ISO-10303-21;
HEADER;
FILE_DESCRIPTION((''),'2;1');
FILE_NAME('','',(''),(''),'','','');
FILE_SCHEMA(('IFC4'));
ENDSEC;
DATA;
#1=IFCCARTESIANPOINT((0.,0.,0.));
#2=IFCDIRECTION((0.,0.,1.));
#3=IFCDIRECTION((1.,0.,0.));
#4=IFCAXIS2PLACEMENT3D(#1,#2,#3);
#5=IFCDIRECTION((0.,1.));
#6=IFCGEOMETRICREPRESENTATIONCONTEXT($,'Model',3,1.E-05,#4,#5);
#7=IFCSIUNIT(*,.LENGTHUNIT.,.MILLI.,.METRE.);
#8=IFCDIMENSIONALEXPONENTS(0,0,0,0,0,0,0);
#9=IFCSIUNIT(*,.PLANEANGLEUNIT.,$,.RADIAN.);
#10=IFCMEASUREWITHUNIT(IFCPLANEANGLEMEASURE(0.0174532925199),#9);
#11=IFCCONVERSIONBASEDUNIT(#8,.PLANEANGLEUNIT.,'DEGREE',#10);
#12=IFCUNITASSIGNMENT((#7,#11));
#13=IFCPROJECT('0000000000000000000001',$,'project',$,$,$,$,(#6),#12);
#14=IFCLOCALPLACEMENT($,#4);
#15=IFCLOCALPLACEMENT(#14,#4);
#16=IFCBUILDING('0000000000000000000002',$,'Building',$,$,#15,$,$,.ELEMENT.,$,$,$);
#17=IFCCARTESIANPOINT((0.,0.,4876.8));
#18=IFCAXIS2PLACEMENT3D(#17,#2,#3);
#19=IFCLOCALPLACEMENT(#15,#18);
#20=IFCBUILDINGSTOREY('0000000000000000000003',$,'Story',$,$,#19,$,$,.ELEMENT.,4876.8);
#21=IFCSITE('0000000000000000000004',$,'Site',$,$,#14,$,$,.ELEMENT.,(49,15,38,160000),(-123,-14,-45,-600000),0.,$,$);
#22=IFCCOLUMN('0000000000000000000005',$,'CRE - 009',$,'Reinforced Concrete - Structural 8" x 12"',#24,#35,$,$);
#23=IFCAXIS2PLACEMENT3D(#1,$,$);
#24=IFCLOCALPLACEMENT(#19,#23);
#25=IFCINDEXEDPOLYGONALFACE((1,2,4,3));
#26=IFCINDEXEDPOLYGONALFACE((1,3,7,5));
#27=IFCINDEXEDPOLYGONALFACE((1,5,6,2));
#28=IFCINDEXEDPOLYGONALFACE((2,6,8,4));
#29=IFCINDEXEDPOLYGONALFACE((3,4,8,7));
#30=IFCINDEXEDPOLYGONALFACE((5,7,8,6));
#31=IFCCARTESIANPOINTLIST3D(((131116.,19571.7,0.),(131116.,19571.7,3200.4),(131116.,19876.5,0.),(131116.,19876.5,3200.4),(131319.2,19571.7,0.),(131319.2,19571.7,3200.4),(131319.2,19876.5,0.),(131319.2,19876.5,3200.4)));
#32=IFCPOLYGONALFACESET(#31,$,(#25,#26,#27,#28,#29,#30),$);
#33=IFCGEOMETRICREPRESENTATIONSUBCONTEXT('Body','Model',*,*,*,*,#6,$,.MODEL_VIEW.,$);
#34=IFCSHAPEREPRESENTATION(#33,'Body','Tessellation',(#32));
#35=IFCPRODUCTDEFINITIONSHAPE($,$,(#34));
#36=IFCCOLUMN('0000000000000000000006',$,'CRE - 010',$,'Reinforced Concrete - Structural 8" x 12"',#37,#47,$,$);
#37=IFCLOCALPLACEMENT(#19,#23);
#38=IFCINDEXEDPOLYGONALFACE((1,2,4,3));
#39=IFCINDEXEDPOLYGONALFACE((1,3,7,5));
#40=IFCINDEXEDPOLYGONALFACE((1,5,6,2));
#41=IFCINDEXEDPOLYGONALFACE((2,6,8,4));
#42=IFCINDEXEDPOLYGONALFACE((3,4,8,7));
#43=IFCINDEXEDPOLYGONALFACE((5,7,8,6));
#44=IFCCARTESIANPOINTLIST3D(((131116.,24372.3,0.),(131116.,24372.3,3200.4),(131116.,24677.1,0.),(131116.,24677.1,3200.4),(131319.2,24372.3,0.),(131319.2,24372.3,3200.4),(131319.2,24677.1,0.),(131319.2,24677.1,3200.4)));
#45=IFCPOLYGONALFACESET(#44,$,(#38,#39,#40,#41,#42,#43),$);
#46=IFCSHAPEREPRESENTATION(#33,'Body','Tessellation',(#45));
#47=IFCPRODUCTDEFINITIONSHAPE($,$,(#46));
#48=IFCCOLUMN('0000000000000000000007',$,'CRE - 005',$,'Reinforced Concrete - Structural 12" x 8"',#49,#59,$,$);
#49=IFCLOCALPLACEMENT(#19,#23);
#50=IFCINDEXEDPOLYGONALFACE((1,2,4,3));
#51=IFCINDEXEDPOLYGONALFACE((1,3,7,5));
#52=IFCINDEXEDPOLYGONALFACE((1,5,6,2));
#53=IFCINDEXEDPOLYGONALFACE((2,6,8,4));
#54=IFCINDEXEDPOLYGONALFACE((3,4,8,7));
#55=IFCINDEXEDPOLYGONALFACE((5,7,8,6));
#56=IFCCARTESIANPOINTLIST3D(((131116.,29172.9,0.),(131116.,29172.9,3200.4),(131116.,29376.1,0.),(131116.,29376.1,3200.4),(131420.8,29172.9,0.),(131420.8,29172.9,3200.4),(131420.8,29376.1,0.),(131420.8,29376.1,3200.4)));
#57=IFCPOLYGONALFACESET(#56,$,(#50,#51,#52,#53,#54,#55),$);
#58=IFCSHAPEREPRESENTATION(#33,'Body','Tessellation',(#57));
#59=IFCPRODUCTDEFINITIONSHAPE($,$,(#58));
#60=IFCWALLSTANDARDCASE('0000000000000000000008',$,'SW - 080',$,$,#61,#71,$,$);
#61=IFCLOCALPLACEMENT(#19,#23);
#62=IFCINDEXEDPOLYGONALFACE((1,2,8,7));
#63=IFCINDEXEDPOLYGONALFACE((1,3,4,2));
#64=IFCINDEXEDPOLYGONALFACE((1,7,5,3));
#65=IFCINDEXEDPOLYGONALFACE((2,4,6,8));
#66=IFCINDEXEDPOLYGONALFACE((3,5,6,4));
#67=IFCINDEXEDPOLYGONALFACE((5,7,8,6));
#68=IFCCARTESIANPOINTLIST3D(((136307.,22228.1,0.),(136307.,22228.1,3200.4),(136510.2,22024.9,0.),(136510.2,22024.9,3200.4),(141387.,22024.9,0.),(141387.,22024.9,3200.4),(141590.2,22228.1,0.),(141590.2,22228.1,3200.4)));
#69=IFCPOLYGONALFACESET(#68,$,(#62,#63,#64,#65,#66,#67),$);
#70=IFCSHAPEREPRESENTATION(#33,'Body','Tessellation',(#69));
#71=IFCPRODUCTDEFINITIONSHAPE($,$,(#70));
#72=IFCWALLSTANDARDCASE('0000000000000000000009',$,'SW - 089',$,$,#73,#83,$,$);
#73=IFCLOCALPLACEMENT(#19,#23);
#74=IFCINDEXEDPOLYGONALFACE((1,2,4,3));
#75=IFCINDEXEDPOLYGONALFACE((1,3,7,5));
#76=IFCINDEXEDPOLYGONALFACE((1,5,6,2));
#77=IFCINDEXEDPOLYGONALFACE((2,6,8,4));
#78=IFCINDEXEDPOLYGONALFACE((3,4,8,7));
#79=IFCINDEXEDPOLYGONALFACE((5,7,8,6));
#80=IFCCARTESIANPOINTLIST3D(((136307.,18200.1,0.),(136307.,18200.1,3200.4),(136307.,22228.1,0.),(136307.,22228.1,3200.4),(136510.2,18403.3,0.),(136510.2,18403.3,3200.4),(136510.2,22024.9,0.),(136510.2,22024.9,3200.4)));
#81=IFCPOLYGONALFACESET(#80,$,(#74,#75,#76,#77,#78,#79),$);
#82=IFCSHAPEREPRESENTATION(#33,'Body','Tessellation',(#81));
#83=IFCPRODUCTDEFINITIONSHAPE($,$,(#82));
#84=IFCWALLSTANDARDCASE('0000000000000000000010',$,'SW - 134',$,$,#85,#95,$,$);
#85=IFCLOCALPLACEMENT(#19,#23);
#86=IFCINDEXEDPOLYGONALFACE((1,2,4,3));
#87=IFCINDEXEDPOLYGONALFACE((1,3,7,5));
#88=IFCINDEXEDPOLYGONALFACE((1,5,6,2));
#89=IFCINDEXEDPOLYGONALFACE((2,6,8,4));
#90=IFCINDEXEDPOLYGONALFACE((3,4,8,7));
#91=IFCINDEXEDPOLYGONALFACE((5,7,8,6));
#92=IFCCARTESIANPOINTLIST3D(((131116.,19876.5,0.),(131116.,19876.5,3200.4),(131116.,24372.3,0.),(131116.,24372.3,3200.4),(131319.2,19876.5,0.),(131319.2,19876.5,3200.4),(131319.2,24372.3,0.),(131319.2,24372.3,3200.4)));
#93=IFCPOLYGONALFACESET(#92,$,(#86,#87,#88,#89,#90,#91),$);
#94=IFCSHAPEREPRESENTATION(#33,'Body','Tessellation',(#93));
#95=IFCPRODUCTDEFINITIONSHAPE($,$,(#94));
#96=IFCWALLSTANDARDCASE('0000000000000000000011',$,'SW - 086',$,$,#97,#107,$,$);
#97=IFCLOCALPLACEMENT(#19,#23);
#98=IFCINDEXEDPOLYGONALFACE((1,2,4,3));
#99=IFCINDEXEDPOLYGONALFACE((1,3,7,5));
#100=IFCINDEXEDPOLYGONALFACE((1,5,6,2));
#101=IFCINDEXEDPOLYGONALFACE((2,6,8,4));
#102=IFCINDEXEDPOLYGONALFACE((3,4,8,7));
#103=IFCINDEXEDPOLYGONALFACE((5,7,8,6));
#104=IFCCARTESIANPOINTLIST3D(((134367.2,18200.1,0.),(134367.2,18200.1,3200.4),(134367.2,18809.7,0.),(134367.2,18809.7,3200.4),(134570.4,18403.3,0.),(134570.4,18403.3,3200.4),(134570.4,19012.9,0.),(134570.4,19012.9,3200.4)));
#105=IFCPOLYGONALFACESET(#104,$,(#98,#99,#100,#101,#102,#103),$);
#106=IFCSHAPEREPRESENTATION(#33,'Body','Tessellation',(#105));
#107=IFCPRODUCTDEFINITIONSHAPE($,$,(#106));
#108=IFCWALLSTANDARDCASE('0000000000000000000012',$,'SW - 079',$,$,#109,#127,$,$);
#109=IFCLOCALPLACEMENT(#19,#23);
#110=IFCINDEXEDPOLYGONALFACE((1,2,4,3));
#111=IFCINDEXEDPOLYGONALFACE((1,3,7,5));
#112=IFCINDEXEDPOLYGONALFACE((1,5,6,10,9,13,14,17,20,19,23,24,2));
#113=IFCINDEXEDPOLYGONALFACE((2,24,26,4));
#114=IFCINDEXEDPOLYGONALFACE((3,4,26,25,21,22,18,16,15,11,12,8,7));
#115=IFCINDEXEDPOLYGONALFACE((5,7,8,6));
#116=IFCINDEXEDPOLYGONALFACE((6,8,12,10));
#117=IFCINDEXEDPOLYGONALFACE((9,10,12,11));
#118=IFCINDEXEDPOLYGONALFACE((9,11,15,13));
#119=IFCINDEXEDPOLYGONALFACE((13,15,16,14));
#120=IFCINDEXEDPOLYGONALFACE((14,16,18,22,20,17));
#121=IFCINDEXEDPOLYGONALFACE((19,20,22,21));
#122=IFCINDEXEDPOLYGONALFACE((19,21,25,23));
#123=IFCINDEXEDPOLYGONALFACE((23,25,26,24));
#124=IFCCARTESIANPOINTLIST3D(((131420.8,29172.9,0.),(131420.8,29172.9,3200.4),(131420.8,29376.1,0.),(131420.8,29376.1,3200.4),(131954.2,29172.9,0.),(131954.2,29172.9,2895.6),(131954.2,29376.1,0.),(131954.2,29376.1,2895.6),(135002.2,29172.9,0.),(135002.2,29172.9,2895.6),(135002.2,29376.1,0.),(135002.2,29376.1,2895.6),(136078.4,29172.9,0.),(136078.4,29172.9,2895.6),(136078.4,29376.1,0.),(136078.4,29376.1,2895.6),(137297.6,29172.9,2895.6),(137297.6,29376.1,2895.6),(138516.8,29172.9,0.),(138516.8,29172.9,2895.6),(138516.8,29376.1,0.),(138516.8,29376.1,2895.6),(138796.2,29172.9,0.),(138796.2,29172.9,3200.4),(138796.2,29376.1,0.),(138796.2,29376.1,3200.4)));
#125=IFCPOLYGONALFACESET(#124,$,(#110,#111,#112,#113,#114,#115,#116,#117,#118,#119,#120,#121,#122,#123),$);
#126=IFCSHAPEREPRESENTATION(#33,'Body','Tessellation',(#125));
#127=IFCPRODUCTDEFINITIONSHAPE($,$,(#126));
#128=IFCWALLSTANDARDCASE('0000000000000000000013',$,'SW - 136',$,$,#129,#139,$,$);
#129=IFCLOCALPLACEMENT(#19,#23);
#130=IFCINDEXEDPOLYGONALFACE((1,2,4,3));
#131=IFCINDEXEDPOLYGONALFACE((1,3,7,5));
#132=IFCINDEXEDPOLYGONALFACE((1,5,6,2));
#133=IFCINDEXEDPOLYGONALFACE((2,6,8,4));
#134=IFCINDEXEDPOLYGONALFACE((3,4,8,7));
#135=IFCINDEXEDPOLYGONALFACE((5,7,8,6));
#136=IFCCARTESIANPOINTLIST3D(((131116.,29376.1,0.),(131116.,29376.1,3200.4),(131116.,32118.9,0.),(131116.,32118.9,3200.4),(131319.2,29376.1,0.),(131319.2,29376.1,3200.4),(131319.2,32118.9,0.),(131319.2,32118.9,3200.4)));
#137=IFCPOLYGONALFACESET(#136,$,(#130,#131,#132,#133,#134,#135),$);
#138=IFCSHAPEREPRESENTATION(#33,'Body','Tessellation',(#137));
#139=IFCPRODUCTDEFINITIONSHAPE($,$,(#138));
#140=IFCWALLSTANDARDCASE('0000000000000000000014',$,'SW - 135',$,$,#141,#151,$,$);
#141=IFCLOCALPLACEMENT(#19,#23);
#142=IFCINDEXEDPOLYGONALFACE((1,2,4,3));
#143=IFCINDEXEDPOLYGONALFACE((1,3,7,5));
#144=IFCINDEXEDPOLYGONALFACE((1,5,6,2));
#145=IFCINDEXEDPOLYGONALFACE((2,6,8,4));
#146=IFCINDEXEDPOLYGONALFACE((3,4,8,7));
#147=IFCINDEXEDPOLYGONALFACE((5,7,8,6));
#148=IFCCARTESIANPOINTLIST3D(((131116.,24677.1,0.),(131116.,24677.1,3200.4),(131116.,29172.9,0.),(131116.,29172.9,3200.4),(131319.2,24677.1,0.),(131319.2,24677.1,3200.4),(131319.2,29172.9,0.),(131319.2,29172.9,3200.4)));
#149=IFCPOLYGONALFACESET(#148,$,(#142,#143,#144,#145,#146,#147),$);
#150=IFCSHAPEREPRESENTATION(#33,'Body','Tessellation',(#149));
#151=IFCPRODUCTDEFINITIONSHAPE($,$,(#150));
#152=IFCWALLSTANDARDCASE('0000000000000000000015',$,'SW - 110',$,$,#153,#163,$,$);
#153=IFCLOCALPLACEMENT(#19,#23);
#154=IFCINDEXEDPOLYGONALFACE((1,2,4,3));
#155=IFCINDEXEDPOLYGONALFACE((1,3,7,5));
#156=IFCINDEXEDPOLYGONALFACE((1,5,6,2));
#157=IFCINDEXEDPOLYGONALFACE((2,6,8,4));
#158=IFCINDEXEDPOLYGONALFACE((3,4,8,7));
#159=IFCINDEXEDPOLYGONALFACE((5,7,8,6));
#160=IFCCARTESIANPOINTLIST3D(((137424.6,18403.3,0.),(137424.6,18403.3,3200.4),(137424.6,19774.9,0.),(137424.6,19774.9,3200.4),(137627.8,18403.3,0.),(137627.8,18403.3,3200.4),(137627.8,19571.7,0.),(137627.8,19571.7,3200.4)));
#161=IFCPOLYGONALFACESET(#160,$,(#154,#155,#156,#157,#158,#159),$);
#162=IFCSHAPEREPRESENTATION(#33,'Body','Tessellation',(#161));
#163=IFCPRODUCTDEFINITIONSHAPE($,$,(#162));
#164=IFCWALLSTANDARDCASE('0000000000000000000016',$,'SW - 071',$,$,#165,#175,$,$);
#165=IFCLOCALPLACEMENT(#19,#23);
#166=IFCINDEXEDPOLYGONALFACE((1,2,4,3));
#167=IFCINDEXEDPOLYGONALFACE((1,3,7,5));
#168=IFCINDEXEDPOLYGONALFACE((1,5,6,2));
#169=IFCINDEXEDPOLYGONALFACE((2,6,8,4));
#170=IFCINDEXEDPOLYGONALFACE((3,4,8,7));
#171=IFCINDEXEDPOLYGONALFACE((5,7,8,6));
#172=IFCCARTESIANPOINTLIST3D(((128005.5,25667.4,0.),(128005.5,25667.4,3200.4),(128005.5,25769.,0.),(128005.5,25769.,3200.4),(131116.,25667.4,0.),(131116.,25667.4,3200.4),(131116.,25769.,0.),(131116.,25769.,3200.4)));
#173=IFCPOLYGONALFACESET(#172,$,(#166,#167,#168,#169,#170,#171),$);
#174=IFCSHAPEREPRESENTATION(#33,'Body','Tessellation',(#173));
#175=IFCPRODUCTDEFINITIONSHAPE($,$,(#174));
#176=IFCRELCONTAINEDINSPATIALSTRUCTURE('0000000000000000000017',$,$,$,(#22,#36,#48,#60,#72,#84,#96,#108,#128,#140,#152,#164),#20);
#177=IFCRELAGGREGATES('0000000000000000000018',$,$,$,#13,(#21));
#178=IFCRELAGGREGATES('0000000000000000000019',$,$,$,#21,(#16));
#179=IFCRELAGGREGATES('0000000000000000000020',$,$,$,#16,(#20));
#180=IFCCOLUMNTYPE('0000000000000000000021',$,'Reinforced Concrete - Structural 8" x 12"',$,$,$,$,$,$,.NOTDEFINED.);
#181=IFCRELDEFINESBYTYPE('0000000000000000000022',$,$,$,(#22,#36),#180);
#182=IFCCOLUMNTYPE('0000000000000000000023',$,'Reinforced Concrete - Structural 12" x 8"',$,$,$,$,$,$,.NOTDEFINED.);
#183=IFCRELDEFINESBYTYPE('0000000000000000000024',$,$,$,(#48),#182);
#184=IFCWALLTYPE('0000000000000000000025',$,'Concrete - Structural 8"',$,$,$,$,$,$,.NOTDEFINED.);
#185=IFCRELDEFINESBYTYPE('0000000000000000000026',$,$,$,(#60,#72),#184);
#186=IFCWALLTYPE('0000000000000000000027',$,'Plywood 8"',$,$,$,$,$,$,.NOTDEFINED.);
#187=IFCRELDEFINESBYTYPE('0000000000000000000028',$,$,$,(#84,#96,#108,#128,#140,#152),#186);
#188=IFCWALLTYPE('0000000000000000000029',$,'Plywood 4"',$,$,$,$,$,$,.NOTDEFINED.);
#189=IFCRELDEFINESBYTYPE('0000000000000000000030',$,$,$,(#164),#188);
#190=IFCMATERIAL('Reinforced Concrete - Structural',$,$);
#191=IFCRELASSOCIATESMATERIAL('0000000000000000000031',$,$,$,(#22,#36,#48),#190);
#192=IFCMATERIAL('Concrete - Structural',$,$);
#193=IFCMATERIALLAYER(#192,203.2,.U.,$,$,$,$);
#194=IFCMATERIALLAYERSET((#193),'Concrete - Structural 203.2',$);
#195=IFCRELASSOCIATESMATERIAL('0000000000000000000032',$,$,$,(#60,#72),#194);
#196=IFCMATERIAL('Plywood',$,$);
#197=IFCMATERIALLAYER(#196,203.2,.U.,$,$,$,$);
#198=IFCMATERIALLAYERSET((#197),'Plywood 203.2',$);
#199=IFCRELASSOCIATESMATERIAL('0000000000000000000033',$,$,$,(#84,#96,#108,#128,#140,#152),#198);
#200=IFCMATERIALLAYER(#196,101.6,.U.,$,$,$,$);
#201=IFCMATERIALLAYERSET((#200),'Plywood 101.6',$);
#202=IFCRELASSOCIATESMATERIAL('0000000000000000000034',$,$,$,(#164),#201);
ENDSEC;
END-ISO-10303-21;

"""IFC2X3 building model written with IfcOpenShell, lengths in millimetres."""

from ifc_helpers import new_model, entity, si_unit, converted_unit, direction, frame, origin_with_axes, origin_2d_with_axis, place, context, subcontext, project, spatial, polyline, rectangle, outline, extrude, material, layer, layer_set, layer_usage, type_object, element, save


model = new_model("IFC2X3")

# Units and contexts
model_context = context("Model", 3, precision=1e-05, world=origin_with_axes(), true_north=direction((0.0, 1.0)))
body_context = subcontext(model_context, "Body", "Model", "MODEL_VIEW")
ifc_project = project(units=[si_unit("LENGTHUNIT", "METRE", prefix="MILLI"), converted_unit("PLANEANGLEUNIT", "DEGREE", entity("IfcPlaneAngleMeasure", 0.0174532925199), si_unit("PLANEANGLEUNIT", "RADIAN"), dimensions=[0, 0, 0, 0, 0, 0, 0])], contexts=[model_context])

# Site, building, storey
site_placement = place(None, origin_with_axes())
site = spatial("IfcSite", under=ifc_project, at=site_placement, Name="Site", CompositionType="ELEMENT", RefLatitude=(49, 15, 38, 160000), RefLongitude=(-123, -14, -45, -600000), RefElevation=0.0)
building_placement = place(site_placement, origin_with_axes())
building = spatial("IfcBuilding", under=site, at=building_placement, Name="Building", CompositionType="ELEMENT")
storey_placement = place(building_placement, frame((0.0, 0.0, 4876.8), z_axis=(0.0, 0.0, 1.0), x_axis=(1.0, 0.0, 0.0)))
storey = spatial("IfcBuildingStorey", under=building, at=storey_placement, Name="Story", CompositionType="ELEMENT", Elevation=4876.8)

# Columns
ifc_material_1 = material(Name="Reinforced Concrete - Structural")
column_type_1 = type_object("IfcColumnType", Name="Reinforced Concrete - Structural 8\" x 12\"", PredefinedType="NOTDEFINED")
for number, where, z_axis, x_axis, name in (
    (1, (131217.6, 19724.1, 0.0), (0.0, 0.0, 1.0), (1.0, 0.0, 0.0), "CRE - 009"),
    (2, (131217.6, 24524.7, 0.0), (0.0, 0.0, 1.0), (1.0, 0.0, 0.0), "CRE - 010"),
):
    element("IfcColumn", number, at=place(storey_placement, frame(where, z_axis=z_axis, x_axis=x_axis)), inside=storey, type_object=column_type_1, material=ifc_material_1, Name=name, ObjectType="Reinforced Concrete - Structural 8\" x 12\"", context=body_context, shape_type="SweptSolid", body=[
        extrude(rectangle(XDim=203.2, YDim=304.8, at=origin_2d_with_axis()), origin_with_axes(), (0.0, 0.0, 1.0), 3200.4),
    ])
column_type_2 = type_object("IfcColumnType", Name="Reinforced Concrete - Structural 12\" x 8\"", PredefinedType="NOTDEFINED")
column_placement = place(storey_placement, frame((131268.4, 29274.5, 0.0), z_axis=(0.0, 0.0, 1.0), x_axis=(1.0, 0.0, 0.0)))
element("IfcColumn", 3, at=column_placement, inside=storey, type_object=column_type_2, material=ifc_material_1, Name="CRE - 005", ObjectType="Reinforced Concrete - Structural 12\" x 8\"", context=body_context, shape_type="SweptSolid", body=[
    extrude(rectangle(XDim=304.8, YDim=203.2, at=origin_2d_with_axis()), origin_with_axes(), (0.0, 0.0, 1.0), 3200.4),
])

# Walls
ifc_material_2 = material(Name="Concrete - Structural")
ifc_layer_1 = layer(ifc_material_2, 203.2, ventilated="UNKNOWN")
ifc_layer_set_1 = layer_set([ifc_layer_1], Name="Concrete - Structural 203.2")
ifc_layer_usage_1 = layer_usage(ifc_layer_set_1, "AXIS2", "POSITIVE", 0.0)
wall_type_1 = type_object("IfcWallType", Name="Concrete - Structural 8\"", PredefinedType="NOTDEFINED")
wall_1_placement = place(storey_placement, frame((136510.2, 22024.9, 0.0), z_axis=(0.0, 0.0, 1.0), x_axis=(1.0, 0.0, 0.0)))
element("IfcWallStandardCase", 4, at=wall_1_placement, inside=storey, type_object=wall_type_1, material=ifc_layer_usage_1, Name="SW - 080", context=body_context, shape_type="SweptSolid", body=[
    extrude(outline(polyline([(0.0, 0.0), (4876.8, 0.0), (5080.0, 203.2), (-203.2, 203.2), (0.0, 0.0)])), origin_with_axes(), (0.0, 0.0, 1.0), 3200.4),
])
ifc_layer_usage_2 = layer_usage(ifc_layer_set_1, "AXIS2", "NEGATIVE", 0.0)
wall_2_placement = place(storey_placement, frame((136510.2, 22024.9, 0.0), z_axis=(0.0, 0.0, 1.0), x_axis=(0.0, -1.0, 0.0)))
element("IfcWallStandardCase", 5, at=wall_2_placement, inside=storey, type_object=wall_type_1, material=ifc_layer_usage_2, Name="SW - 089", context=body_context, shape_type="SweptSolid", body=[
    extrude(outline(polyline([(-203.2, -203.2), (3824.8, -203.2), (3621.6, 0.0), (0.0, 0.0), (-203.2, -203.2)])), origin_with_axes(), (0.0, 0.0, 1.0), 3200.4),
])

# Walls
ifc_material_3 = material(Name="Plywood")
ifc_layer_2 = layer(ifc_material_3, 203.2, ventilated="UNKNOWN")
ifc_layer_set_2 = layer_set([ifc_layer_2], Name="Plywood 203.2")
ifc_layer_usage_3 = layer_usage(ifc_layer_set_2, "AXIS2", "NEGATIVE", 0.0)
wall_type_2 = type_object("IfcWallType", Name="Plywood 8\"", PredefinedType="NOTDEFINED")
wall_3_placement = place(storey_placement, frame((131116.0, 19876.5, 0.0), z_axis=(0.0, 0.0, 1.0), x_axis=(0.0, 1.0, 0.0)))
element("IfcWallStandardCase", 6, at=wall_3_placement, inside=storey, type_object=wall_type_2, material=ifc_layer_usage_3, Name="SW - 134", context=body_context, shape_type="SweptSolid", body=[
    extrude(outline(polyline([(0.0, -203.2), (4495.8, -203.2), (4495.8, 0.0), (0.0, 0.0), (0.0, -203.2)])), origin_with_axes(), (0.0, 0.0, 1.0), 3200.4),
])
ifc_layer_usage_4 = layer_usage(ifc_layer_set_2, "AXIS2", "POSITIVE", 0.0)
wall_4_placement = place(storey_placement, frame((134367.2, 19012.9, 0.0), z_axis=(0.0, 0.0, 1.0), x_axis=(0.0, -1.0, 0.0)))
element("IfcWallStandardCase", 7, at=wall_4_placement, inside=storey, type_object=wall_type_2, material=ifc_layer_usage_4, Name="SW - 086", context=body_context, shape_type="SweptSolid", body=[
    extrude(outline(polyline([(203.2, 0.0), (812.8, 0.0), (609.6, 203.2), (0.0, 203.2), (203.2, 0.0)])), origin_with_axes(), (0.0, 0.0, 1.0), 3200.4),
])

# Wall, openings
ifc_layer_usage_5 = layer_usage(ifc_layer_set_2, "AXIS2", "POSITIVE", 0.0)
wall_5_placement = place(storey_placement, frame((131420.8, 29172.9, 0.0), z_axis=(0.0, 0.0, 1.0), x_axis=(1.0, 0.0, 0.0)))
wall_5 = element("IfcWallStandardCase", 8, at=wall_5_placement, inside=storey, type_object=wall_type_2, material=ifc_layer_usage_5, Name="SW - 079", context=body_context, shape_type="SweptSolid", body=[
    extrude(outline(polyline([(0.0, 0.0), (7375.4, 0.0), (7375.4, 203.2), (0.0, 203.2), (0.0, 0.0)])), origin_with_axes(), (0.0, 0.0, 1.0), 3200.4),
])
opening_1_placement = place(wall_5_placement, frame((5267.2, 0.0, 0.0), z_axis=(0.0, 0.0, 1.0), x_axis=(1.0, 0.0, 0.0)))
element("IfcOpeningElement", 9, at=opening_1_placement, cuts=wall_5, context=body_context, shape_type="SweptSolid", body=[
    extrude(rectangle(XDim=1219.2, YDim=2895.6, at=origin_2d_with_axis()), frame((0.0, -203.2, 1447.8), z_axis=(0.0, 1.0, 0.0), x_axis=(1.0, 0.0, 0.0)), (0.0, 0.0, 1.0), 609.6),
])
opening_2_placement = place(wall_5_placement, frame((6486.4, 0.0, 0.0), z_axis=(0.0, 0.0, 1.0), x_axis=(1.0, 0.0, 0.0)))
element("IfcOpeningElement", 10, at=opening_2_placement, cuts=wall_5, context=body_context, shape_type="SweptSolid", body=[
    extrude(rectangle(XDim=1219.2, YDim=2895.6, at=origin_2d_with_axis()), frame((0.0, -203.2, 1447.8), z_axis=(0.0, -1.0, 0.0), x_axis=(-1.0, 0.0, 0.0)), (0.0, 0.0, -1.0), 609.6),
])
opening_3_placement = place(wall_5_placement, frame((2057.4, 0.0, 0.0), z_axis=(0.0, 0.0, 1.0), x_axis=(1.0, 0.0, 0.0)))
element("IfcOpeningElement", 11, at=opening_3_placement, cuts=wall_5, context=body_context, shape_type="SweptSolid", body=[
    extrude(rectangle(XDim=3048.0, YDim=2895.6, at=origin_2d_with_axis()), frame((0.0, -203.2, 1447.8), z_axis=(0.0, -1.0, 0.0), x_axis=(-1.0, 0.0, 0.0)), (0.0, 0.0, -1.0), 609.6),
])

# Walls
ifc_layer_usage_6 = layer_usage(ifc_layer_set_2, "AXIS2", "NEGATIVE", 0.0)
wall_6_placement = place(storey_placement, frame((131116.0, 29376.1, 0.0), z_axis=(0.0, 0.0, 1.0), x_axis=(0.0, 1.0, 0.0)))
element("IfcWallStandardCase", 12, at=wall_6_placement, inside=storey, type_object=wall_type_2, material=ifc_layer_usage_6, Name="SW - 136", context=body_context, shape_type="SweptSolid", body=[
    extrude(outline(polyline([(0.0, -203.2), (2742.9, -203.2), (2742.9, 0.0), (0.0, 0.0), (0.0, -203.2)])), origin_with_axes(), (0.0, 0.0, 1.0), 3200.4),
])
ifc_layer_usage_7 = layer_usage(ifc_layer_set_2, "AXIS2", "NEGATIVE", 0.0)
wall_7_placement = place(storey_placement, frame((131116.0, 24677.1, 0.0), z_axis=(0.0, 0.0, 1.0), x_axis=(0.0, 1.0, 0.0)))
element("IfcWallStandardCase", 13, at=wall_7_placement, inside=storey, type_object=wall_type_2, material=ifc_layer_usage_7, Name="SW - 135", context=body_context, shape_type="SweptSolid", body=[
    extrude(outline(polyline([(0.0, -203.2), (4495.8, -203.2), (4495.8, 0.0), (0.0, 0.0), (0.0, -203.2)])), origin_with_axes(), (0.0, 0.0, 1.0), 3200.4),
])
ifc_layer_usage_8 = layer_usage(ifc_layer_set_2, "AXIS2", "POSITIVE", 0.0)
wall_8_placement = place(storey_placement, frame((137424.6, 19774.9, 0.0), z_axis=(0.0, 0.0, 1.0), x_axis=(0.0, -1.0, 0.0)))
element("IfcWallStandardCase", 14, at=wall_8_placement, inside=storey, type_object=wall_type_2, material=ifc_layer_usage_8, Name="SW - 110", context=body_context, shape_type="SweptSolid", body=[
    extrude(outline(polyline([(0.0, 0.0), (1371.6, 0.0), (1371.6, 203.2), (203.2, 203.2), (0.0, 0.0)])), origin_with_axes(), (0.0, 0.0, 1.0), 3200.4),
])

# Shared definitions
ifc_layer_3 = layer(ifc_material_3, 101.6, ventilated="UNKNOWN")
ifc_layer_set_3 = layer_set([ifc_layer_3], Name="Plywood 101.6")
wall_type_3 = type_object("IfcWallType", Name="Plywood 4\"", PredefinedType="NOTDEFINED")

# Wall
ifc_layer_usage_9 = layer_usage(ifc_layer_set_3, "AXIS2", "POSITIVE", 0.0)
wall_9_placement = place(storey_placement, frame((131116.0, 25769.0, 0.0), z_axis=(0.0, 0.0, 1.0), x_axis=(-1.0, 0.0, 0.0)))
element("IfcWallStandardCase", 15, at=wall_9_placement, inside=storey, type_object=wall_type_3, material=ifc_layer_usage_9, Name="SW - 071", context=body_context, shape_type="SweptSolid", body=[
    extrude(outline(polyline([(0.0, 0.0), (3110.6, 0.0), (3110.6, 101.6), (0.0, 101.6), (0.0, 0.0)])), origin_with_axes(), (0.0, 0.0, 1.0), 3200.4),
])

save(model, "model.ifc")
